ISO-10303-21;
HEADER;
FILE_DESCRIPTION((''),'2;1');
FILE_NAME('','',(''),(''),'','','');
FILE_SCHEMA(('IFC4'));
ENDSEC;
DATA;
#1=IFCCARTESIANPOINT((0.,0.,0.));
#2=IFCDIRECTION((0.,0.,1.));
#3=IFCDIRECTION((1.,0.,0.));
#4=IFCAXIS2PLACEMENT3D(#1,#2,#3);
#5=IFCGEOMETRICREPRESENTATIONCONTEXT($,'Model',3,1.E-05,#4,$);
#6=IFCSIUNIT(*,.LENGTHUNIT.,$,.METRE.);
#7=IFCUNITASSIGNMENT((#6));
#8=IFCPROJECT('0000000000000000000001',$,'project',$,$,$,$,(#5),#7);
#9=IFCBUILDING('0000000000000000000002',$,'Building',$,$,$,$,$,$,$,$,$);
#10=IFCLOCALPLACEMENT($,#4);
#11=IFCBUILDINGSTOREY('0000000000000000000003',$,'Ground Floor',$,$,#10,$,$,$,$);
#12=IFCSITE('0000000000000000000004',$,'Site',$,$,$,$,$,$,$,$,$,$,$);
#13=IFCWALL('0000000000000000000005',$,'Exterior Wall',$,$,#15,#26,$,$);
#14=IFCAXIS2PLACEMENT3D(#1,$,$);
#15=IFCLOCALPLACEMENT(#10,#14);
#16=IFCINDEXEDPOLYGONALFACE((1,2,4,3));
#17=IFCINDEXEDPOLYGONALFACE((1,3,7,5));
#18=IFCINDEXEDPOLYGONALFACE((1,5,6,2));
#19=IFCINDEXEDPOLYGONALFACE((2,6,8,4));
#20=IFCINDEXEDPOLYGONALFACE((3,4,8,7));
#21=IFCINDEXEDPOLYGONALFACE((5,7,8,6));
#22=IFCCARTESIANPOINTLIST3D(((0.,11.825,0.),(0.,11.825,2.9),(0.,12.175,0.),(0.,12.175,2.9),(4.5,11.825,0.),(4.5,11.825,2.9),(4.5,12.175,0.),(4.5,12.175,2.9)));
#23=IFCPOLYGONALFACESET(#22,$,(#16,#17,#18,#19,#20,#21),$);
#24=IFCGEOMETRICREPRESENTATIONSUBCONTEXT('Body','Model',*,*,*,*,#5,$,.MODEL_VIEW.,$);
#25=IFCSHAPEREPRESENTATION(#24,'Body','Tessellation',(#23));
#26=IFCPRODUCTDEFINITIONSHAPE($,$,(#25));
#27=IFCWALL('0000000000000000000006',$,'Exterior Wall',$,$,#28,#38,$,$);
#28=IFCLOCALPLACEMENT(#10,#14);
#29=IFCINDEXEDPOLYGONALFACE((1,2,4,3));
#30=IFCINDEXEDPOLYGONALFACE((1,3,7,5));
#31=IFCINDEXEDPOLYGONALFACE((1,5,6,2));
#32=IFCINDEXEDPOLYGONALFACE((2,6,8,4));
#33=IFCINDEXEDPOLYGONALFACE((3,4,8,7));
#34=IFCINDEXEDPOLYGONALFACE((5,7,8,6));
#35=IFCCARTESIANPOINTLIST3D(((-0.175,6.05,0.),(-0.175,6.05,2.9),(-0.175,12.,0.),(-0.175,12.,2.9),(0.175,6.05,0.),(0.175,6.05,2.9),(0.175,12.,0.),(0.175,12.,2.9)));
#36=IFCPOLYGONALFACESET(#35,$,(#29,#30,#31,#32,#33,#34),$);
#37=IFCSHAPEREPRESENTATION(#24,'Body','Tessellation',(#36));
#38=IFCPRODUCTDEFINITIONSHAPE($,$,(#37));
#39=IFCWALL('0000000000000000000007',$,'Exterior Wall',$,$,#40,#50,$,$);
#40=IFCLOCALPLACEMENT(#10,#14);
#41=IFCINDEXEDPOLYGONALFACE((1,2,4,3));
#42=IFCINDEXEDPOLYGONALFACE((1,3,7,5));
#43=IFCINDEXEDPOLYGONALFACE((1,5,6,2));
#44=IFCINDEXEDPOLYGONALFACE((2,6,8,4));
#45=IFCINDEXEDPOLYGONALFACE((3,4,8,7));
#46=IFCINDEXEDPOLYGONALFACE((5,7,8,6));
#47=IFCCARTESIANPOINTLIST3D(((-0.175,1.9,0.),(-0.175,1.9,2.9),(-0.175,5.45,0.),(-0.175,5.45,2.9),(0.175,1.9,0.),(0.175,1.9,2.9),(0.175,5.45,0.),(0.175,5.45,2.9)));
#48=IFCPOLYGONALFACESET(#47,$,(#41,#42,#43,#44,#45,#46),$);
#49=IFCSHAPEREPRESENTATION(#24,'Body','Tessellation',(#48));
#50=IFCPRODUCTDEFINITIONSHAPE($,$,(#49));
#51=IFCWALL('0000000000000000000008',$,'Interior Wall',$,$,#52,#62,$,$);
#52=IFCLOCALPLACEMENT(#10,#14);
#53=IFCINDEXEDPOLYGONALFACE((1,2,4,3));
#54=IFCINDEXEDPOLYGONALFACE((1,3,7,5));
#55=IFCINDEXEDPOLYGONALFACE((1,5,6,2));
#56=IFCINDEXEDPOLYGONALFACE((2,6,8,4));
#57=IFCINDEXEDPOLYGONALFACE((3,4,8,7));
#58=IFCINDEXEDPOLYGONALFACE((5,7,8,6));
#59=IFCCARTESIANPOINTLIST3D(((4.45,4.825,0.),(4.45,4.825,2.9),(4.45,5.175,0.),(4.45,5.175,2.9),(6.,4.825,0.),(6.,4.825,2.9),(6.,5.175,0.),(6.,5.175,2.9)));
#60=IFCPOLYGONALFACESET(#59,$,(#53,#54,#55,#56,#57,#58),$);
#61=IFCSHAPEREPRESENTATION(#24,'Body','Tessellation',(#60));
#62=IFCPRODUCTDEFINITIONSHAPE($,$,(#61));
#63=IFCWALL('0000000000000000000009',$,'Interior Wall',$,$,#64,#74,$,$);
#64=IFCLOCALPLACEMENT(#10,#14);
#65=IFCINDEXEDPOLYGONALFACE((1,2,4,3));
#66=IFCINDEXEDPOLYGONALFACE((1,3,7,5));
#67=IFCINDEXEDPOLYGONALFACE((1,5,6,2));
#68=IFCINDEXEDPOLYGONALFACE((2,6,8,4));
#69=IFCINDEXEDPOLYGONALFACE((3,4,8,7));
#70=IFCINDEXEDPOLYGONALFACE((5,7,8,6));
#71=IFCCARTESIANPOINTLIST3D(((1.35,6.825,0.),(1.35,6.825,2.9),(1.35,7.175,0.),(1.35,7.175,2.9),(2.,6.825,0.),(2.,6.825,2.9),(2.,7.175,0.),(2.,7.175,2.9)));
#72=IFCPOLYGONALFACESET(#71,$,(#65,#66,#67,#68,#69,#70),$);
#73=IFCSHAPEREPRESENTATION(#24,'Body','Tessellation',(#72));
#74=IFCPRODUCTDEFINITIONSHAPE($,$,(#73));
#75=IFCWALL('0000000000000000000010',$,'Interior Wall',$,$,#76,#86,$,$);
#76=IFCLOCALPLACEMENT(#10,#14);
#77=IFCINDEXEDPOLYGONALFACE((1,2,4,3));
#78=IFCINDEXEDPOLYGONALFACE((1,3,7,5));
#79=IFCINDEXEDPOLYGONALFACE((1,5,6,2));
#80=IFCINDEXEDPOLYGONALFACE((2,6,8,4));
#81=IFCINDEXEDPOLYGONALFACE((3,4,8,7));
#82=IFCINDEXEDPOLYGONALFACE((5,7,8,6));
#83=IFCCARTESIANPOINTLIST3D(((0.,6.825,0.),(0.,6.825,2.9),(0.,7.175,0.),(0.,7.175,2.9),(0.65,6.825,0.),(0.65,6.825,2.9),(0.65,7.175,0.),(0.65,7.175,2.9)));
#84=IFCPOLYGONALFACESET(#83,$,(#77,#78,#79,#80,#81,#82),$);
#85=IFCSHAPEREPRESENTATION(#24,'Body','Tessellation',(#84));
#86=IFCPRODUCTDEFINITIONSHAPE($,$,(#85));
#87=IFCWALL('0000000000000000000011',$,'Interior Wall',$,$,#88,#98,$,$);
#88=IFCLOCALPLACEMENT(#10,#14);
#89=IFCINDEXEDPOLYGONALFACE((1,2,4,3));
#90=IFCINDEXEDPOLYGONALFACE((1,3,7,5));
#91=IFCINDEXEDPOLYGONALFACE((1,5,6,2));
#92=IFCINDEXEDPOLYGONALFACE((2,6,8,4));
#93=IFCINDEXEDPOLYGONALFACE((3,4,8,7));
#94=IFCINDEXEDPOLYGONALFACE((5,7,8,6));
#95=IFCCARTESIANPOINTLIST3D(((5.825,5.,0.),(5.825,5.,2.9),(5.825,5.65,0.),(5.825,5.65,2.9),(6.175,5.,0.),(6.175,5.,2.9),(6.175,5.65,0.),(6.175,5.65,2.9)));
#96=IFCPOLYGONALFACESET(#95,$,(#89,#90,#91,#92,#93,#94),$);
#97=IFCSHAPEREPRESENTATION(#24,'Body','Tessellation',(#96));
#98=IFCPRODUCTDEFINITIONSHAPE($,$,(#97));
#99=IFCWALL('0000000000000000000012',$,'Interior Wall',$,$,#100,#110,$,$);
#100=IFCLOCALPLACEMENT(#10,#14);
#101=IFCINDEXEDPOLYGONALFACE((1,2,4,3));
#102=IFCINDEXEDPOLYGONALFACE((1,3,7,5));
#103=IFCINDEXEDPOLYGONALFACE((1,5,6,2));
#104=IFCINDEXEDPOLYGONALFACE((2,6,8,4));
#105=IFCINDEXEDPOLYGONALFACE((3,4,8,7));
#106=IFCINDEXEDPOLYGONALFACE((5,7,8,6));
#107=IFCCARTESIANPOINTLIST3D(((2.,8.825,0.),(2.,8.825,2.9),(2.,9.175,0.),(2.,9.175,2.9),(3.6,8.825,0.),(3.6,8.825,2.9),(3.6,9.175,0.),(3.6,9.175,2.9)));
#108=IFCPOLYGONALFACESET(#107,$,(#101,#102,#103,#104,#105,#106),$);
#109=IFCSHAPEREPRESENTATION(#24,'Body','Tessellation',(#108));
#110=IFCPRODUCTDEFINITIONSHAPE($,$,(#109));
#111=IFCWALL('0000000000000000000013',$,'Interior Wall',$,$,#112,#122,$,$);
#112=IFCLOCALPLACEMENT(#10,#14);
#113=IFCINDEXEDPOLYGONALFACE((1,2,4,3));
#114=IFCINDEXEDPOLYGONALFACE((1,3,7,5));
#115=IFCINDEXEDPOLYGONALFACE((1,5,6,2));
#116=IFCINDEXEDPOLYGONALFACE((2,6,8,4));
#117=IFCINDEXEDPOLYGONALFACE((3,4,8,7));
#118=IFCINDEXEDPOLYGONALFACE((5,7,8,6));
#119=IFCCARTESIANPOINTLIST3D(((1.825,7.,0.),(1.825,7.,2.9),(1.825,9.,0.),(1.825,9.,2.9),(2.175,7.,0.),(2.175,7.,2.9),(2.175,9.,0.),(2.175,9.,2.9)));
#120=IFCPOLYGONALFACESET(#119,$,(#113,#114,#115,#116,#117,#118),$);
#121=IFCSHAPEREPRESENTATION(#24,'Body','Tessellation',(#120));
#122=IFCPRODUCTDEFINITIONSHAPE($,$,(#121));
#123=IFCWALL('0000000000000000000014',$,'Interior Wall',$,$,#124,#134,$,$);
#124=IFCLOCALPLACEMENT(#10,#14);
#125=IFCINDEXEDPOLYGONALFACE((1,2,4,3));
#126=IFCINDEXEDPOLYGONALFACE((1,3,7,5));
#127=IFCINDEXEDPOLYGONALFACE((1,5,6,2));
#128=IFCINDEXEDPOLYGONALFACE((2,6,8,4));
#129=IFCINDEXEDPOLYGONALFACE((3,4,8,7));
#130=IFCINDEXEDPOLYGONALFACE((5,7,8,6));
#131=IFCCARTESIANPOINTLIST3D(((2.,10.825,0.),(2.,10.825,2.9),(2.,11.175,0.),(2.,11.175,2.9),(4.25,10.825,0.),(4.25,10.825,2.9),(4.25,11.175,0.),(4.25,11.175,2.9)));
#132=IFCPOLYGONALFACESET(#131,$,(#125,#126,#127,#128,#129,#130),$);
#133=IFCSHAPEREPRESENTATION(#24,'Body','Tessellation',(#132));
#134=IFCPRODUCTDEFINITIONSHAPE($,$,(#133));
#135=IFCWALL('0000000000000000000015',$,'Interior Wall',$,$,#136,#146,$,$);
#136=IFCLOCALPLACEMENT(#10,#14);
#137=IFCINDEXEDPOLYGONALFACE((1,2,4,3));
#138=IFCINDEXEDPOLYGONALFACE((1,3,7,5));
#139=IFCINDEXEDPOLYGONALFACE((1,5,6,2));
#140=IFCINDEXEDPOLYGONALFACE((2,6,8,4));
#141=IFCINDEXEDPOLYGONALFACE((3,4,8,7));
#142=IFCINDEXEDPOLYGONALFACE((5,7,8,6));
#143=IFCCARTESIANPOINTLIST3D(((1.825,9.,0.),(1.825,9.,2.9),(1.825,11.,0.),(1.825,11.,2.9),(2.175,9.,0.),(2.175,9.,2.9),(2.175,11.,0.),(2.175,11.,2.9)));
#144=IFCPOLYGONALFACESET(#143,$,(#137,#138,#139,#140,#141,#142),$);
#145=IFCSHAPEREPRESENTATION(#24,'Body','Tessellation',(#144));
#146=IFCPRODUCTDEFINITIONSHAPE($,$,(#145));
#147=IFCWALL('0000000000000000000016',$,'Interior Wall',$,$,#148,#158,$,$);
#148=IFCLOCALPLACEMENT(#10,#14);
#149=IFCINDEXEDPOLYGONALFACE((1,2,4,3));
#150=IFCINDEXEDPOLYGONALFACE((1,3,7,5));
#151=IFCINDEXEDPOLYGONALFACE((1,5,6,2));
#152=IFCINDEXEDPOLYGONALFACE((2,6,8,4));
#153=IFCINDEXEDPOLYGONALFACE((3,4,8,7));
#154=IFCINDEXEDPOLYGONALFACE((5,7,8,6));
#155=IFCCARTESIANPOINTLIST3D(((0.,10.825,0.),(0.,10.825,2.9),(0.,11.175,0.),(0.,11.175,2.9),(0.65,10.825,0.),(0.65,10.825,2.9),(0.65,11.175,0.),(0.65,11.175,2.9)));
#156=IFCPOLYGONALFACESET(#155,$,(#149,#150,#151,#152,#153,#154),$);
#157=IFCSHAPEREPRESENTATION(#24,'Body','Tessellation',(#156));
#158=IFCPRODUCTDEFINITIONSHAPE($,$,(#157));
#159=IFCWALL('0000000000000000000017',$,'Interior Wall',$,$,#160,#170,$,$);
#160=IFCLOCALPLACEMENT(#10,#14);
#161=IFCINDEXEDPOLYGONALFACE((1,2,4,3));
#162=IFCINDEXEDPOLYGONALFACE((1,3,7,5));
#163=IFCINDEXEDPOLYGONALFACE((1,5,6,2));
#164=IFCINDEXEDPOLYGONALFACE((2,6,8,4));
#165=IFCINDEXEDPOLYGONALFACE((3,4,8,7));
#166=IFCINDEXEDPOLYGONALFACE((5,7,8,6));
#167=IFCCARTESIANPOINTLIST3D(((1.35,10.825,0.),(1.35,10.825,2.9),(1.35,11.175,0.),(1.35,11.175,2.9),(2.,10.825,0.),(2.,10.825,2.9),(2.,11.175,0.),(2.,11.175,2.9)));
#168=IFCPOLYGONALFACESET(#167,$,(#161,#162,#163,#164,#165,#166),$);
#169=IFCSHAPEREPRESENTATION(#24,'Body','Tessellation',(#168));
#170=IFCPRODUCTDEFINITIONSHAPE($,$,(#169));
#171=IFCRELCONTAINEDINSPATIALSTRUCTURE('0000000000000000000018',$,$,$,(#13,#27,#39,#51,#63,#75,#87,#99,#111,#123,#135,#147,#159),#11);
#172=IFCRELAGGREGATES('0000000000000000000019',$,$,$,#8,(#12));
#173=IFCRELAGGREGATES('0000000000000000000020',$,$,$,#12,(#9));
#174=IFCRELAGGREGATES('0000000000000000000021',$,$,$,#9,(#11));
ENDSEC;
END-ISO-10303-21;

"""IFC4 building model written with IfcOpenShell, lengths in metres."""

from ifc_helpers import new_model, si_unit, frame, origin_with_axes, place, context, subcontext, project, spatial, indexed_curve, outline, extrude, element, save


model = new_model("IFC4")

# Units and contexts
model_context = context("Model", 3, precision=1e-05, world=origin_with_axes())
body_context = subcontext(model_context, "Body", "Model", "MODEL_VIEW")
ifc_project = project(units=[si_unit("LENGTHUNIT", "METRE")], contexts=[model_context])

# Site, building, storey
site = spatial("IfcSite", under=ifc_project, Name="Site")
building = spatial("IfcBuilding", under=site, Name="Building")
storey_placement = place(None, origin_with_axes())
storey = spatial("IfcBuildingStorey", under=building, at=storey_placement, Name="Ground Floor")

# Walls
wall_1_placement = place(storey_placement, frame((4.5, 12.0, 0.0), z_axis=(0.0, 0.0, 1.0), x_axis=(-1.0, 0.0, 0.0)))
element("IfcWall", 1, at=wall_1_placement, inside=storey, Name="Exterior Wall", context=body_context, shape_type="SweptSolid", body=[
    extrude(outline(indexed_curve([(0.0, 0.0), (0.0, 0.35), (4.5, 0.35), (4.5, 0.0), (0.0, 0.0)], self_intersect=False)), frame((0.0, -0.175, 0.0), z_axis=(0.0, 0.0, 1.0), x_axis=(1.0, 0.0, 0.0)), (0.0, 0.0, 1.0), 2.9),
])
wall_2_placement = place(storey_placement, frame((0.0, 12.0, 0.0), z_axis=(0.0, 0.0, 1.0), x_axis=(0.0, -1.0, 0.0)))
element("IfcWall", 2, at=wall_2_placement, inside=storey, Name="Exterior Wall", context=body_context, shape_type="SweptSolid", body=[
    extrude(outline(indexed_curve([(0.0, 0.0), (0.0, 0.35), (5.95, 0.35), (5.95, 0.0), (0.0, 0.0)], self_intersect=False)), frame((0.0, -0.175, 0.0), z_axis=(0.0, 0.0, 1.0), x_axis=(1.0, 0.0, 0.0)), (0.0, 0.0, 1.0), 2.9),
])
wall_3_placement = place(storey_placement, frame((0.0, 5.45, 0.0), z_axis=(0.0, 0.0, 1.0), x_axis=(0.0, -1.0, 0.0)))
element("IfcWall", 3, at=wall_3_placement, inside=storey, Name="Exterior Wall", context=body_context, shape_type="SweptSolid", body=[
    extrude(outline(indexed_curve([(0.0, 0.0), (0.0, 0.35), (3.55, 0.35), (3.55, 0.0), (0.0, 0.0)], self_intersect=False)), frame((0.0, -0.175, 0.0), z_axis=(0.0, 0.0, 1.0), x_axis=(1.0, 0.0, 0.0)), (0.0, 0.0, 1.0), 2.9),
])
wall_4_placement = place(storey_placement, frame((6.0, 5.0, 0.0), z_axis=(0.0, 0.0, 1.0), x_axis=(-1.0, 0.0, 0.0)))
element("IfcWall", 4, at=wall_4_placement, inside=storey, Name="Interior Wall", context=body_context, shape_type="SweptSolid", body=[
    extrude(outline(indexed_curve([(0.0, 0.0), (0.0, 0.35), (1.55, 0.35), (1.55, 0.0), (0.0, 0.0)], self_intersect=False)), frame((0.0, -0.175, 0.0), z_axis=(0.0, 0.0, 1.0), x_axis=(1.0, 0.0, 0.0)), (0.0, 0.0, 1.0), 2.9),
])
for number, where, z_axis, x_axis, name in (
    (5, (2.0, 7.0, 0.0), (0.0, 0.0, 1.0), (-1.0, 0.0, 0.0), "Interior Wall"),
    (6, (0.65, 7.0, 0.0), (0.0, 0.0, 1.0), (-1.0, 0.0, 0.0), "Interior Wall"),
):
    element("IfcWall", number, at=place(storey_placement, frame(where, z_axis=z_axis, x_axis=x_axis)), inside=storey, Name=name, context=body_context, shape_type="SweptSolid", body=[
        extrude(outline(indexed_curve([(0.0, 0.0), (0.0, 0.35), (0.65, 0.35), (0.65, 0.0), (0.0, 0.0)], self_intersect=False)), frame((0.0, -0.175, 0.0), z_axis=(0.0, 0.0, 1.0), x_axis=(1.0, 0.0, 0.0)), (0.0, 0.0, 1.0), 2.9),
    ])
wall_5_placement = place(storey_placement, frame((6.0, 5.0, 0.0), z_axis=(0.0, 0.0, 1.0), x_axis=(0.0, 1.0, 0.0)))
element("IfcWall", 7, at=wall_5_placement, inside=storey, Name="Interior Wall", context=body_context, shape_type="SweptSolid", body=[
    extrude(outline(indexed_curve([(0.0, 0.0), (0.0, 0.35), (0.65, 0.35), (0.65, 0.0), (0.0, 0.0)], self_intersect=False)), frame((0.0, -0.175, 0.0), z_axis=(0.0, 0.0, 1.0), x_axis=(1.0, 0.0, 0.0)), (0.0, 0.0, 1.0), 2.9),
])
wall_6_placement = place(storey_placement, frame((3.6, 9.0, 0.0), z_axis=(0.0, 0.0, 1.0), x_axis=(-1.0, 0.0, 0.0)))
element("IfcWall", 8, at=wall_6_placement, inside=storey, Name="Interior Wall", context=body_context, shape_type="SweptSolid", body=[
    extrude(outline(indexed_curve([(0.0, 0.0), (0.0, 0.35), (1.6, 0.35), (1.6, 0.0), (0.0, 0.0)], self_intersect=False)), frame((0.0, -0.175, 0.0), z_axis=(0.0, 0.0, 1.0), x_axis=(1.0, 0.0, 0.0)), (0.0, 0.0, 1.0), 2.9),
])
wall_7_placement = place(storey_placement, frame((2.0, 9.0, 0.0), z_axis=(0.0, 0.0, 1.0), x_axis=(0.0, -1.0, 0.0)))
element("IfcWall", 9, at=wall_7_placement, inside=storey, Name="Interior Wall", context=body_context, shape_type="SweptSolid", body=[
    extrude(outline(indexed_curve([(0.0, 0.0), (0.0, 0.35), (2.0, 0.35), (2.0, 0.0), (0.0, 0.0)], self_intersect=False)), frame((0.0, -0.175, 0.0), z_axis=(0.0, 0.0, 1.0), x_axis=(1.0, 0.0, 0.0)), (0.0, 0.0, 1.0), 2.9),
])
wall_8_placement = place(storey_placement, frame((4.25, 11.0, 0.0), z_axis=(0.0, 0.0, 1.0), x_axis=(-1.0, 0.0, 0.0)))
element("IfcWall", 10, at=wall_8_placement, inside=storey, Name="Interior Wall", context=body_context, shape_type="SweptSolid", body=[
    extrude(outline(indexed_curve([(0.0, 0.0), (0.0, 0.35), (2.25, 0.35), (2.25, 0.0), (0.0, 0.0)], self_intersect=False)), frame((0.0, -0.175, 0.0), z_axis=(0.0, 0.0, 1.0), x_axis=(1.0, 0.0, 0.0)), (0.0, 0.0, 1.0), 2.9),
])
wall_9_placement = place(storey_placement, frame((2.0, 11.0, 0.0), z_axis=(0.0, 0.0, 1.0), x_axis=(0.0, -1.0, 0.0)))
element("IfcWall", 11, at=wall_9_placement, inside=storey, Name="Interior Wall", context=body_context, shape_type="SweptSolid", body=[
    extrude(outline(indexed_curve([(0.0, 0.0), (0.0, 0.35), (2.0, 0.35), (2.0, 0.0), (0.0, 0.0)], self_intersect=False)), frame((0.0, -0.175, 0.0), z_axis=(0.0, 0.0, 1.0), x_axis=(1.0, 0.0, 0.0)), (0.0, 0.0, 1.0), 2.9),
])
wall_10_placement = place(storey_placement, frame((0.0, 11.0, 0.0), z_axis=(0.0, 0.0, 1.0), x_axis=(1.0, 0.0, 0.0)))
element("IfcWall", 12, at=wall_10_placement, inside=storey, Name="Interior Wall", context=body_context, shape_type="SweptSolid", body=[
    extrude(outline(indexed_curve([(0.0, 0.0), (0.0, 0.35), (0.65, 0.35), (0.65, 0.0), (0.0, 0.0)], self_intersect=False)), frame((0.0, -0.175, 0.0), z_axis=(0.0, 0.0, 1.0), x_axis=(1.0, 0.0, 0.0)), (0.0, 0.0, 1.0), 2.9),
])
wall_11_placement = place(storey_placement, frame((1.35, 11.0, 0.0), z_axis=(0.0, 0.0, 1.0), x_axis=(1.0, 0.0, 0.0)))
element("IfcWall", 13, at=wall_11_placement, inside=storey, Name="Interior Wall", context=body_context, shape_type="SweptSolid", body=[
    extrude(outline(indexed_curve([(0.0, 0.0), (0.0, 0.35), (0.65, 0.35), (0.65, 0.0), (0.0, 0.0)], self_intersect=False)), frame((0.0, -0.175, 0.0), z_axis=(0.0, 0.0, 1.0), x_axis=(1.0, 0.0, 0.0)), (0.0, 0.0, 1.0), 2.9),
])

save(model, "model.ifc")
